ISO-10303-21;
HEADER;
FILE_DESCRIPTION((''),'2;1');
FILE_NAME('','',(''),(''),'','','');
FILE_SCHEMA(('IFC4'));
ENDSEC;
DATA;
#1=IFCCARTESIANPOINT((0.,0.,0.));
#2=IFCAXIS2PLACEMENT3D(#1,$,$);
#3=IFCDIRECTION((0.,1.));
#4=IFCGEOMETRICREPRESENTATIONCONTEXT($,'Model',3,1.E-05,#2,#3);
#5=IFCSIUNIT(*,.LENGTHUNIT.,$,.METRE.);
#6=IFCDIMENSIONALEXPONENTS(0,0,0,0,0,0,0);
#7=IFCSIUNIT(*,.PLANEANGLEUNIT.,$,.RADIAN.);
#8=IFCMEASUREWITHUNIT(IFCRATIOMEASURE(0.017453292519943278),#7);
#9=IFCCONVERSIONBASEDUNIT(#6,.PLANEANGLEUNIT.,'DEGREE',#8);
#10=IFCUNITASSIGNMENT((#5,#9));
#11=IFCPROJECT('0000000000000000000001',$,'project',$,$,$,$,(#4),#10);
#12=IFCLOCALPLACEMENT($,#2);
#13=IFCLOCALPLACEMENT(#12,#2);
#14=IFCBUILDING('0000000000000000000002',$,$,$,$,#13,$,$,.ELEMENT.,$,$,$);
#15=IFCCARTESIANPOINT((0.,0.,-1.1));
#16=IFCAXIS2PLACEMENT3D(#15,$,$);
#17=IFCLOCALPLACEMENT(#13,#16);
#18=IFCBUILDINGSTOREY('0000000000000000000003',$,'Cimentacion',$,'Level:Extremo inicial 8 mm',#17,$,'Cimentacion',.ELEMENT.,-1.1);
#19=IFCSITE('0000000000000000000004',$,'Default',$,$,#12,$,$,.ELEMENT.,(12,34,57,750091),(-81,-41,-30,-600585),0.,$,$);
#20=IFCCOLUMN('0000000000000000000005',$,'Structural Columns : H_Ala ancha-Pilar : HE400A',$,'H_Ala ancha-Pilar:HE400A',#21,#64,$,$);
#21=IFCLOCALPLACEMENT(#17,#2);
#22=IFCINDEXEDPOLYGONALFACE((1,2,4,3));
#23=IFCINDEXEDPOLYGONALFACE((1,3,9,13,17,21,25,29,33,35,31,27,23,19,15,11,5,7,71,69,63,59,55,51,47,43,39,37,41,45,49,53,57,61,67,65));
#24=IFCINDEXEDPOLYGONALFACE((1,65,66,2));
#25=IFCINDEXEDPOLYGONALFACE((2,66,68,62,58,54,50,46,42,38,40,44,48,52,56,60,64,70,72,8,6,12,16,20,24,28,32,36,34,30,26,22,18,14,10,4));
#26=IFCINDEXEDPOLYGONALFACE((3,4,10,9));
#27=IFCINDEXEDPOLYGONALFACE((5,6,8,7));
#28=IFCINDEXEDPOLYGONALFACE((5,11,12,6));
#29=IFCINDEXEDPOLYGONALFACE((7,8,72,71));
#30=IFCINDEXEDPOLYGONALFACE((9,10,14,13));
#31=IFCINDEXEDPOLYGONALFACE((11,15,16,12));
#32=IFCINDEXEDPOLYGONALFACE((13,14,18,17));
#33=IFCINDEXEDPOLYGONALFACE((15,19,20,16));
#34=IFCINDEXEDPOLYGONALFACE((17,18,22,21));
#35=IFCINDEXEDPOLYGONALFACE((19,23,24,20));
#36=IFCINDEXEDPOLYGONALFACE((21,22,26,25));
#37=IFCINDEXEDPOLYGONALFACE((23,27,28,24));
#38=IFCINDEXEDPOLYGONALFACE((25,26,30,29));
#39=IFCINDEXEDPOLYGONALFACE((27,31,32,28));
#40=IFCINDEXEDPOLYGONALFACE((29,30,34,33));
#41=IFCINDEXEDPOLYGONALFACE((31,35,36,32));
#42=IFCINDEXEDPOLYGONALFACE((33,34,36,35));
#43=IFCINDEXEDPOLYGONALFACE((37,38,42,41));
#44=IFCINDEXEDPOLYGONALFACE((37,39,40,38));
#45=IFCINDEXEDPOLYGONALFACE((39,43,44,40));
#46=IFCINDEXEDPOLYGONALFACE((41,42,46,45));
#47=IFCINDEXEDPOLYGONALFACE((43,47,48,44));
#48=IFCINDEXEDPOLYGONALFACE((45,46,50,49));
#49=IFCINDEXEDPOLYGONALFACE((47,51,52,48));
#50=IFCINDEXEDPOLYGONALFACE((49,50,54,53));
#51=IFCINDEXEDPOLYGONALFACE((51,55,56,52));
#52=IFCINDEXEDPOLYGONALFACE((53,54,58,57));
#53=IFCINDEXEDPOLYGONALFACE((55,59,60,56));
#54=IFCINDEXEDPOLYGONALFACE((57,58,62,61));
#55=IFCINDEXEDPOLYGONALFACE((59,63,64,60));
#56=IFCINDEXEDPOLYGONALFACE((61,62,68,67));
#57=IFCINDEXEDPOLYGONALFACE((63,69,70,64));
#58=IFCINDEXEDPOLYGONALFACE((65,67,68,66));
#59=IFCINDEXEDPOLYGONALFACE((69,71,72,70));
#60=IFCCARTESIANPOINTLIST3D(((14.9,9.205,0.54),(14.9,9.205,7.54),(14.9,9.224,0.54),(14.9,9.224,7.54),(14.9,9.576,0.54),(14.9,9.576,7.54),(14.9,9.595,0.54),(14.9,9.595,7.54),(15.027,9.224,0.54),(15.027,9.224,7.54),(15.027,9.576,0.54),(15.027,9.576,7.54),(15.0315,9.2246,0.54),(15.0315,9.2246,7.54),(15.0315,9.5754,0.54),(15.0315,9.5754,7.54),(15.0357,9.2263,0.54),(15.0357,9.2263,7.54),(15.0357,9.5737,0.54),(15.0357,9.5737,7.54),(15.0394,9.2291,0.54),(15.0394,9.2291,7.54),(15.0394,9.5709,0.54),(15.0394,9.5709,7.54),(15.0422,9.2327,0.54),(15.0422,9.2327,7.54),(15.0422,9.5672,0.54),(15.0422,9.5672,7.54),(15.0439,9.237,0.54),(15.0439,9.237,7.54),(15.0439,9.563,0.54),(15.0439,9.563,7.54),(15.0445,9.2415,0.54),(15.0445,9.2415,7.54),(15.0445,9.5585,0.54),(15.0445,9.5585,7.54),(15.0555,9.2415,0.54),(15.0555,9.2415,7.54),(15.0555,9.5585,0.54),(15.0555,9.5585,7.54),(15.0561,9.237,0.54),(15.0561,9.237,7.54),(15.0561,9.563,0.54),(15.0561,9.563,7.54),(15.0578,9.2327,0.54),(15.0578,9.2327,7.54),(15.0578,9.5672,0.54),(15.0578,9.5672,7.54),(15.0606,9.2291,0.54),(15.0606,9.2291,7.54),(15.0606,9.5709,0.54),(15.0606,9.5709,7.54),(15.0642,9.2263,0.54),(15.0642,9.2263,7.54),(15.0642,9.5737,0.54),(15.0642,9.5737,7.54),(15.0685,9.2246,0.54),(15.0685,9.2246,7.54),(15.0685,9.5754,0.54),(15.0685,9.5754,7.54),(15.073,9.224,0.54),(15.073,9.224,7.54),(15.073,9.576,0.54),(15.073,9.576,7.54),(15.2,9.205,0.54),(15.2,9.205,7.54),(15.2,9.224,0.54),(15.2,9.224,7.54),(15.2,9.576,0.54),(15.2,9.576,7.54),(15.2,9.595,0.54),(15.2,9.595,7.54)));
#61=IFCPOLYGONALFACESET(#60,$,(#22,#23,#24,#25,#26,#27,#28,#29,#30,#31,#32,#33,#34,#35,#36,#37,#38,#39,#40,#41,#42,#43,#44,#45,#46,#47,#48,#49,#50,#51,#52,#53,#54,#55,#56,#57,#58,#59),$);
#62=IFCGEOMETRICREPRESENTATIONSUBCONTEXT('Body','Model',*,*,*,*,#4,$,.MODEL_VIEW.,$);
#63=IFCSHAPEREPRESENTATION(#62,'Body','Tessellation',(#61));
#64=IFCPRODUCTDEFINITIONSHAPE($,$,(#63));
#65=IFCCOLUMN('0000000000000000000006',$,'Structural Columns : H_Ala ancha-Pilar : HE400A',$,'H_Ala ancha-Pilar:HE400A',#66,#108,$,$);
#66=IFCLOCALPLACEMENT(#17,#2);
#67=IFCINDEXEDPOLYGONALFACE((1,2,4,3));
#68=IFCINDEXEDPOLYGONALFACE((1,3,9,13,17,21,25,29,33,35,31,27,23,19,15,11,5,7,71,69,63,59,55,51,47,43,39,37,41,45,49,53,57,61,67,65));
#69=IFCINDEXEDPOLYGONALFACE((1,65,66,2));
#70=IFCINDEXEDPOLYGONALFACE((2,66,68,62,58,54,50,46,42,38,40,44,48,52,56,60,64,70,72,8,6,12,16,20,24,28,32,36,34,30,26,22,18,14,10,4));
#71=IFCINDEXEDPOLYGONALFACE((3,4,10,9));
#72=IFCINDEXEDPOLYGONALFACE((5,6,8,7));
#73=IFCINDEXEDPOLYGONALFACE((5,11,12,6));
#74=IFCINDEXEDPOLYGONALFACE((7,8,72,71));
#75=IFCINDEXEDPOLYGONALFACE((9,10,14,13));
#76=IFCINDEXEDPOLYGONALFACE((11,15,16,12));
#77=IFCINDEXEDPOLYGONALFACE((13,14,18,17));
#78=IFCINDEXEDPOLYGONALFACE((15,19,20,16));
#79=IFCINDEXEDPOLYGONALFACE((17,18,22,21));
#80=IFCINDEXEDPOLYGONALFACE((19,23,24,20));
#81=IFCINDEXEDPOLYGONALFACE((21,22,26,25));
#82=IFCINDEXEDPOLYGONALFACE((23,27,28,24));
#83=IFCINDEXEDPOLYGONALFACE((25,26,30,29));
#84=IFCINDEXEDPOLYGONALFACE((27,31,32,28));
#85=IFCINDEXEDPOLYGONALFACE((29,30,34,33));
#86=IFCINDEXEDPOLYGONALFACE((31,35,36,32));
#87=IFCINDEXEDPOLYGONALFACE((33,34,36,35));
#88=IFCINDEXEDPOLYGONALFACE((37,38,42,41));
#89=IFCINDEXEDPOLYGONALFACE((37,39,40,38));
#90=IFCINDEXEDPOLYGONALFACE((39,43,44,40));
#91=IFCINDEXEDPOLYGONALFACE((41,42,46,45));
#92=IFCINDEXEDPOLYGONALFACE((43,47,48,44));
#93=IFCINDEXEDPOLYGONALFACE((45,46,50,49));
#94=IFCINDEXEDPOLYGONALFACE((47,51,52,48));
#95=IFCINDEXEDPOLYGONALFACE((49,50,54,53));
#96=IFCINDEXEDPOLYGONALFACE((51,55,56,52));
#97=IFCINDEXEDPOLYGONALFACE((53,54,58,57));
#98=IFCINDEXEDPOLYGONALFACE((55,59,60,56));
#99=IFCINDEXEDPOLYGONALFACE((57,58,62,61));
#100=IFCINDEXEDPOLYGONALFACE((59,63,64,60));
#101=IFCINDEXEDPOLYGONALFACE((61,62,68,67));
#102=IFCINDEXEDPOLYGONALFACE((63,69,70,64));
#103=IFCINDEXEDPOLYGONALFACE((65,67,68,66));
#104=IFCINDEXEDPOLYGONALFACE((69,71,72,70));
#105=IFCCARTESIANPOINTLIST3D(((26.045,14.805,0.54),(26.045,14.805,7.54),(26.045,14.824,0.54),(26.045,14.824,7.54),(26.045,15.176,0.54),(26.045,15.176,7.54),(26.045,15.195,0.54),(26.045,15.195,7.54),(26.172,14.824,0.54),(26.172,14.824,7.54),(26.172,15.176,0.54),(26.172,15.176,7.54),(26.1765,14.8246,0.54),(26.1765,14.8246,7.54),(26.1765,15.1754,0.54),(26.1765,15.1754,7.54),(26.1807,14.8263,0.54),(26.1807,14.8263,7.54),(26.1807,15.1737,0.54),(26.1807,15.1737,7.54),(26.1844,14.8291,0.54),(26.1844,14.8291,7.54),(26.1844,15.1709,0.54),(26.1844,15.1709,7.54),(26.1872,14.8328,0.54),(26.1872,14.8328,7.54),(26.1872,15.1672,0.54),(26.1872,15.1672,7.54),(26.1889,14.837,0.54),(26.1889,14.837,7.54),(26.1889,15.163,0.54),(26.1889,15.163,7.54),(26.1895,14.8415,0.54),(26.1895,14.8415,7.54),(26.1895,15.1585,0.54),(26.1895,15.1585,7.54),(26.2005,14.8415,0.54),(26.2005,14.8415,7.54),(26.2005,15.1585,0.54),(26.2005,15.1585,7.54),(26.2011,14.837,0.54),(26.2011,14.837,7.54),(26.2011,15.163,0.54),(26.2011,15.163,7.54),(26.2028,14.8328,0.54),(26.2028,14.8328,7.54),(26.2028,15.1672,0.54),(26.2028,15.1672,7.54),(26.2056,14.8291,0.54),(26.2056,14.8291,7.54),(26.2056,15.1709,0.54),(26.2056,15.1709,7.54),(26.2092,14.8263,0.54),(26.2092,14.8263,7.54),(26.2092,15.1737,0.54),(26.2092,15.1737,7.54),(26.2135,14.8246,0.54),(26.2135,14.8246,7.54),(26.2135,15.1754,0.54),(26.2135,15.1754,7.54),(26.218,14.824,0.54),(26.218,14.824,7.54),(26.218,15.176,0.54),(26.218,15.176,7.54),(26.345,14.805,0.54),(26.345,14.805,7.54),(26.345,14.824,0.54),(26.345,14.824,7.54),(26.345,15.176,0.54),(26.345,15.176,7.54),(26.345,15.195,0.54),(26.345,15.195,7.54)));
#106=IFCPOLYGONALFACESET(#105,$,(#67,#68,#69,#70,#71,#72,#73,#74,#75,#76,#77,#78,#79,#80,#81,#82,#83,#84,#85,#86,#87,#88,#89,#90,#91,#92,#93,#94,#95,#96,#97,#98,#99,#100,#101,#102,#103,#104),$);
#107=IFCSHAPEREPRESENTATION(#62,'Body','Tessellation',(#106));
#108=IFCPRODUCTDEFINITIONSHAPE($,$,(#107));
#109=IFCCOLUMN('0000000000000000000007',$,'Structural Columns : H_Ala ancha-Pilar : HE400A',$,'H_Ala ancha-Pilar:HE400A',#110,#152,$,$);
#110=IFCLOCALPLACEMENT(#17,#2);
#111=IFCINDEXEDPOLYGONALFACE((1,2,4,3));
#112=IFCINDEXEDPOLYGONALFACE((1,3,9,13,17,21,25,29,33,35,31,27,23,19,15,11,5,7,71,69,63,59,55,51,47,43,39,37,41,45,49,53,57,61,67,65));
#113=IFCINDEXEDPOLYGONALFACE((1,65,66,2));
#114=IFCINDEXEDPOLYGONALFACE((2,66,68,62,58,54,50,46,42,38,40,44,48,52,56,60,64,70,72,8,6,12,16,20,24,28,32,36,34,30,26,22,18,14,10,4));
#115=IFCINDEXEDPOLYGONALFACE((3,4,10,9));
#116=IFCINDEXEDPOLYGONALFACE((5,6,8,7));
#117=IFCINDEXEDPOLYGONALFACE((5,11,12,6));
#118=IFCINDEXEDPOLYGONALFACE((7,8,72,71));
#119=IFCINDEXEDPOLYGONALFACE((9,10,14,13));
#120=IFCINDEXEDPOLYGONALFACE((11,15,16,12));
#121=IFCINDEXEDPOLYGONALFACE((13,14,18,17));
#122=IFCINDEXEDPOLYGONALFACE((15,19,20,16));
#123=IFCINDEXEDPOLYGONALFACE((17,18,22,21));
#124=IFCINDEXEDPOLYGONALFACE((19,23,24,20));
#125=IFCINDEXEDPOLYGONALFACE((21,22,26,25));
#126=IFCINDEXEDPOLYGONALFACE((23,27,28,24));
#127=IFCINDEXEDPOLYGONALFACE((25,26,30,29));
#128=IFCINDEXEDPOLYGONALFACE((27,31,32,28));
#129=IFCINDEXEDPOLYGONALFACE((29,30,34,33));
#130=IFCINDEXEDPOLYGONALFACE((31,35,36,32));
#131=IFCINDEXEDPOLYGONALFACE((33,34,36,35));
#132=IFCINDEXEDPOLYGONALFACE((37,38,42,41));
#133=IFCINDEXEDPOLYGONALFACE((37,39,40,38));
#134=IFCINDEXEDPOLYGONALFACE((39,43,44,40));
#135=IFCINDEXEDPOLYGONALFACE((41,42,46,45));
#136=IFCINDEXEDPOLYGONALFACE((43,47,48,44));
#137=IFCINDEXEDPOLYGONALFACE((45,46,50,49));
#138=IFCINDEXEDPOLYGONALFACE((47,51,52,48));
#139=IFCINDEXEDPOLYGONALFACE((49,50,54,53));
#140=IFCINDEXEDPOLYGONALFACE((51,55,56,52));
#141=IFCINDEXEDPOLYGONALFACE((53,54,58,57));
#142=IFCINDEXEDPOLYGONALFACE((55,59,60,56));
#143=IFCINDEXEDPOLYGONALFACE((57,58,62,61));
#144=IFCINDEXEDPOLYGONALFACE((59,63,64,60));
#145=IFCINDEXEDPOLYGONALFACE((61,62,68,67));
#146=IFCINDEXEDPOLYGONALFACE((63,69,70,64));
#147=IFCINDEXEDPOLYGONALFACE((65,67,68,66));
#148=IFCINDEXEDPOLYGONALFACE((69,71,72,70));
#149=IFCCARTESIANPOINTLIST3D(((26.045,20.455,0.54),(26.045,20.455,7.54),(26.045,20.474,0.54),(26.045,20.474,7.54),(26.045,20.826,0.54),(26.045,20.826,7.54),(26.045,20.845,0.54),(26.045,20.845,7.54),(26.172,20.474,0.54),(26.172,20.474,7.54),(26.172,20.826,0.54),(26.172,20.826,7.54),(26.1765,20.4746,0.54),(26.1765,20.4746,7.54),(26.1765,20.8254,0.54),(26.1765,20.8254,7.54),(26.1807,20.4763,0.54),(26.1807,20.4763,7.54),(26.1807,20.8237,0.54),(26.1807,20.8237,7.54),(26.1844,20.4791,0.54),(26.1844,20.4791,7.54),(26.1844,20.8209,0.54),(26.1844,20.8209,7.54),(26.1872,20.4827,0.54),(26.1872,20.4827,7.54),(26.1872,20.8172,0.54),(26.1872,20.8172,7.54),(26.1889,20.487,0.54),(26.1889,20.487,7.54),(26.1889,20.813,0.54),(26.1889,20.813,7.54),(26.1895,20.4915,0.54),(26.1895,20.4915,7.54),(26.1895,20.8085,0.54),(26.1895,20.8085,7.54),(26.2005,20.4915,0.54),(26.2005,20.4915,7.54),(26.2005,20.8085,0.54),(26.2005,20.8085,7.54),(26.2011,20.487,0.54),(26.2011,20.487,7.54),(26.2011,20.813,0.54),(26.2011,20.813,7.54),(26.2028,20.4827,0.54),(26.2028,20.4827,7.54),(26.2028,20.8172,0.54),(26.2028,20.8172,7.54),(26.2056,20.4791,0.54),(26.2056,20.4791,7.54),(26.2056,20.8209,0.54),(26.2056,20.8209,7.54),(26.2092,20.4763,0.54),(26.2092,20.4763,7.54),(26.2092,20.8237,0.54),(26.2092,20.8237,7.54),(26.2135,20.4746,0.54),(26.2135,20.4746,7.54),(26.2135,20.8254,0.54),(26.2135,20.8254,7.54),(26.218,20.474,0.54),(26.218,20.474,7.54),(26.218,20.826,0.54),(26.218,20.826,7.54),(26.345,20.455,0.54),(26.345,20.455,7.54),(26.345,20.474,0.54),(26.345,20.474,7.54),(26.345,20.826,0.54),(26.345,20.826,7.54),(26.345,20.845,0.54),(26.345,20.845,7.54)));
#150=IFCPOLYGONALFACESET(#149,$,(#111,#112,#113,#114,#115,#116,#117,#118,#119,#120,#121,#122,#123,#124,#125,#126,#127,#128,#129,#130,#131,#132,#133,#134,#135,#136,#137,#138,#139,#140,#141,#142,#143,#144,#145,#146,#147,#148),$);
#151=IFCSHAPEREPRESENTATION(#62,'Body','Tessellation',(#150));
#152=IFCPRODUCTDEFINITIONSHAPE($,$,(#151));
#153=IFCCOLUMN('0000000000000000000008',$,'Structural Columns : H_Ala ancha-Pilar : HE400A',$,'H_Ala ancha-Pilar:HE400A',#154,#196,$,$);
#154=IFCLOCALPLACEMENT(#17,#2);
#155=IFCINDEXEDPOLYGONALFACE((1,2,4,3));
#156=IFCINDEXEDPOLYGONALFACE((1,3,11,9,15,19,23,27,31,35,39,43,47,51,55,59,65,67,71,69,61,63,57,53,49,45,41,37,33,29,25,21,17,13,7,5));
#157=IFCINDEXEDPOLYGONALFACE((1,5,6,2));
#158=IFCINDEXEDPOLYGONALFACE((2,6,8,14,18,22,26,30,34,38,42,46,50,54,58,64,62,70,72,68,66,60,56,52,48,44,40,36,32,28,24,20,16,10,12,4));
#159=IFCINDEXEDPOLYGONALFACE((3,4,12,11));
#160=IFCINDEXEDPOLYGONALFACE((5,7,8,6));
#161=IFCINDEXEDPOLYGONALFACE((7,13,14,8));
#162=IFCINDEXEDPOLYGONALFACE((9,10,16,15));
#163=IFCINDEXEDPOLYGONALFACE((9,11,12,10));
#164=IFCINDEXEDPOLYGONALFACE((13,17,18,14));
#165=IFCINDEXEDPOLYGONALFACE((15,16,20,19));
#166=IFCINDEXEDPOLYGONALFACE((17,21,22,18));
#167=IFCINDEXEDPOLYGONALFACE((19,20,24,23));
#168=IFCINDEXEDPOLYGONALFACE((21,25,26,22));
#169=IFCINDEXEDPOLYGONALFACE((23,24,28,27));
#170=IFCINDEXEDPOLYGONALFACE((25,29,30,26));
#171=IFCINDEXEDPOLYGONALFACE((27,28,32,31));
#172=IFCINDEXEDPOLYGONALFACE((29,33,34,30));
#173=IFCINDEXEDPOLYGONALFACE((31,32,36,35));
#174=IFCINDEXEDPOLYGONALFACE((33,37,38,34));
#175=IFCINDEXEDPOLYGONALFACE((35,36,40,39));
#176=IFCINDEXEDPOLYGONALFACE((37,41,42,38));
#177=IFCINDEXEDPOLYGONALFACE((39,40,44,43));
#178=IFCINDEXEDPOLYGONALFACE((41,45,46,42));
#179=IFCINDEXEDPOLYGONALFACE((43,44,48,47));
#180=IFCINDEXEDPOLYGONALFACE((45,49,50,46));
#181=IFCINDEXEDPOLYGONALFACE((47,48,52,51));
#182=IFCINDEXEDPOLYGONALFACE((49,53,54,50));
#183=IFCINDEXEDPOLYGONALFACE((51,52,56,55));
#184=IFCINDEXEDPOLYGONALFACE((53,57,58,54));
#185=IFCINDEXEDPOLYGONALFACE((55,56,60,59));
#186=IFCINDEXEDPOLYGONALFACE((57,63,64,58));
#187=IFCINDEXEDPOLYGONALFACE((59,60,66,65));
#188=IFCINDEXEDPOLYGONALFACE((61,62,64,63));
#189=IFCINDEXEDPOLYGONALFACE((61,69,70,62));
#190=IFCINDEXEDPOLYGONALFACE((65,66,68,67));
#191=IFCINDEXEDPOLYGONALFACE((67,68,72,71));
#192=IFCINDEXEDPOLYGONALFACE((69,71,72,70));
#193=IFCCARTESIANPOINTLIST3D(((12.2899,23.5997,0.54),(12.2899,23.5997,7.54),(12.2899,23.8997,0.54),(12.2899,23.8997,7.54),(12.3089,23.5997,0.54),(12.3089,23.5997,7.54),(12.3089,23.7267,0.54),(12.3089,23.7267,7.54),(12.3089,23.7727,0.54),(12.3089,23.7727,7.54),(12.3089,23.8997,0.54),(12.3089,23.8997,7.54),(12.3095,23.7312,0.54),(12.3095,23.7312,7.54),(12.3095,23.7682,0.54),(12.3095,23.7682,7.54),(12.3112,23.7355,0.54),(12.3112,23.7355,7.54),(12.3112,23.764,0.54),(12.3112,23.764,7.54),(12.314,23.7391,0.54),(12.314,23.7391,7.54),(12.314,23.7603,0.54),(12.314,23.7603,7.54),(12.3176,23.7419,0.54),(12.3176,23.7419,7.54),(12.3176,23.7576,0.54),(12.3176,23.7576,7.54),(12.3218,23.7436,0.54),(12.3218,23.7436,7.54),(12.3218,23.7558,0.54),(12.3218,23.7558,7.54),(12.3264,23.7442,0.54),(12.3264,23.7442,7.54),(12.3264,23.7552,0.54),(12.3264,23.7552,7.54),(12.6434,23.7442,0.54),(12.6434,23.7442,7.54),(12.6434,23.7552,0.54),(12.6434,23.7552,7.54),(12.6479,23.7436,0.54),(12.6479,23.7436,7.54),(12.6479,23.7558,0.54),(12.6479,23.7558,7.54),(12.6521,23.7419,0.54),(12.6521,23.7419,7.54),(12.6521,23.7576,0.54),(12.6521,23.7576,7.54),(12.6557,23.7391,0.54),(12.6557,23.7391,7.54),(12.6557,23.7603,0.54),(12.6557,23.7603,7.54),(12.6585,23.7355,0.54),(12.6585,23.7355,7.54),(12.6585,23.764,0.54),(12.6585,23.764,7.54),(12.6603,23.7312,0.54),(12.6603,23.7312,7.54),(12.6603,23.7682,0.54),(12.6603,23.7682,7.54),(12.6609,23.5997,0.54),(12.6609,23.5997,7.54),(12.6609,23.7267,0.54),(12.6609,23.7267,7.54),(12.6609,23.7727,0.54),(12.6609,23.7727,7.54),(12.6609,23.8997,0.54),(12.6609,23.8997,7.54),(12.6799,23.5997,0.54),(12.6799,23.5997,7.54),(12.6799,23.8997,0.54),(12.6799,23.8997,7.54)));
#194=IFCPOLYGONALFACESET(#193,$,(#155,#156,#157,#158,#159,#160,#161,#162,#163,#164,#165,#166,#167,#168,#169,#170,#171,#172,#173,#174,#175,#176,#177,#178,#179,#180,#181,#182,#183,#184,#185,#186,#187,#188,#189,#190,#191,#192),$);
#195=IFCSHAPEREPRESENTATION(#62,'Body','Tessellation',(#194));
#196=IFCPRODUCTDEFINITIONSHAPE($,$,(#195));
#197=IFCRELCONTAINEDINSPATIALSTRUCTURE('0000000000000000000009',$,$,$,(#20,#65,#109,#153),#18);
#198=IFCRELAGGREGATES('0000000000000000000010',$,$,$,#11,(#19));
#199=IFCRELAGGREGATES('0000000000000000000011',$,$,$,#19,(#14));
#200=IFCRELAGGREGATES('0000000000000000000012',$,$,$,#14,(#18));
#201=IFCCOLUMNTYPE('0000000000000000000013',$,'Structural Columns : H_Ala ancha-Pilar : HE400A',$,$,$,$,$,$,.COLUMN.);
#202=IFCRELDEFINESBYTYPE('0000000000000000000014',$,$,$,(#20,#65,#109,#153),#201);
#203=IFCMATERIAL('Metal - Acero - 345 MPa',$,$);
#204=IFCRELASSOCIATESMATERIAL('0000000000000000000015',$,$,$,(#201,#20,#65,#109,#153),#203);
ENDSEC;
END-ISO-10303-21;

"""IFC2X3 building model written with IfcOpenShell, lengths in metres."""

from ifc_helpers import new_model, entity, si_unit, converted_unit, direction, frame, frame_2d, origin, place, context, subcontext, project, spatial, polyline, circle_curve, parameter, trimmed, segment, composite_curve, outline, extrude, source, transform, mapped, material, type_object, type_shapes, element, save


model = new_model("IFC2X3")

# Units and contexts
model_context = context("Model", 3, precision=1e-05, world=origin(), true_north=direction((0.0, 1.0)))
body_context = subcontext(model_context, "Body", "Model", "MODEL_VIEW")
ifc_project = project(units=[si_unit("LENGTHUNIT", "METRE"), converted_unit("PLANEANGLEUNIT", "DEGREE", entity("IfcRatioMeasure", 0.017453292519943278), si_unit("PLANEANGLEUNIT", "RADIAN"), dimensions=[0, 0, 0, 0, 0, 0, 0])], contexts=[model_context])

# Site, building, storey
site_placement = place(None, origin())
site = spatial("IfcSite", under=ifc_project, at=site_placement, Name="Default", CompositionType="ELEMENT", RefLatitude=(12, 34, 57, 750091), RefLongitude=(-81, -41, -30, -600585), RefElevation=0.0)
building_placement = place(site_placement, origin())
building = spatial("IfcBuilding", under=site, at=building_placement, CompositionType="ELEMENT")
storey_placement = place(building_placement, frame((0.0, 0.0, -1.1)))
storey = spatial("IfcBuildingStorey", under=building, at=storey_placement, Name="Cimentacion", ObjectType="Level:Extremo inicial 8 mm", LongName="Cimentacion", CompositionType="ELEMENT", Elevation=-1.1)

# Columns
ifc_material = material(Name="Metal - Acero - 345 MPa")
column_type_1 = type_object("IfcColumnType", Name="Structural Columns : H_Ala ancha-Pilar : HE400A", PredefinedType="COLUMN", material=ifc_material)
shared_shape_1 = source(origin(), body_context, "Body", "SweptSolid", [
    extrude(outline(composite_curve([segment(polyline([(0.176, -0.15), (0.195, -0.15)]), True, "CONTINUOUS"), segment(polyline([(0.195, -0.15), (0.195, 0.15)]), True, "CONTINUOUS"), segment(polyline([(0.195, 0.15), (0.176, 0.15)]), True, "CONTINUOUS"), segment(polyline([(0.176, 0.15), (0.176, 0.023)]), True, "CONTINUOUS"), segment(trimmed(circle_curve(frame_2d((0.1585, 0.023), x_axis=(1.0, 0.0)), 0.0175), [parameter(270.0)], [parameter(0.0)], True, "PARAMETER"), False, "CONTINUOUS"), segment(polyline([(0.1585, 0.0055), (-0.1585, 0.0055)]), True, "CONTINUOUS"), segment(trimmed(circle_curve(frame_2d((-0.1585, 0.023), x_axis=(0.0, -1.0)), 0.0175), [parameter(270.0)], [parameter(0.0)], True, "PARAMETER"), False, "CONTINUOUS"), segment(polyline([(-0.176, 0.023), (-0.176, 0.15)]), True, "CONTINUOUS"), segment(polyline([(-0.176, 0.15), (-0.195, 0.15)]), True, "CONTINUOUS"), segment(polyline([(-0.195, 0.15), (-0.195, -0.15)]), True, "CONTINUOUS"), segment(polyline([(-0.195, -0.15), (-0.176, -0.15)]), True, "CONTINUOUS"), segment(polyline([(-0.176, -0.15), (-0.176, -0.023)]), True, "CONTINUOUS"), segment(trimmed(circle_curve(frame_2d((-0.1585, -0.023), x_axis=(-1.0, 0.0)), 0.0175), [parameter(270.0)], [parameter(0.0)], True, "PARAMETER"), False, "CONTINUOUS"), segment(polyline([(-0.1585, -0.0055), (0.1585, -0.0055)]), True, "CONTINUOUS"), segment(trimmed(circle_curve(frame_2d((0.1585, -0.023), x_axis=(0.0, 1.0)), 0.0175), [parameter(270.0)], [parameter(0.0)], True, "PARAMETER"), False, "CONTINUOUS"), segment(polyline([(0.176, -0.023), (0.176, -0.15)]), True, "CONTINUOUS")], self_intersect=False)), frame((0.0, 0.0, -0.56), z_axis=(0.0, 0.0, 1.0), x_axis=(0.0, -1.0, 0.0)), (0.0, 0.0, 1.0), 7.0),
])
type_shapes(column_type_1, [shared_shape_1])
for number, where, z_axis, x_axis, name in (
    (1, (15.05, 9.4, 1.1), (0.0, 0.0, 1.0), (-1.0, 0.0, 0.0), "Structural Columns : H_Ala ancha-Pilar : HE400A"),
    (2, (26.195, 15.0, 1.1), (0.0, 0.0, 1.0), (-1.0, 0.0, 0.0), "Structural Columns : H_Ala ancha-Pilar : HE400A"),
    (3, (26.195, 20.65, 1.1), (0.0, 0.0, 1.0), (-1.0, 0.0, 0.0), "Structural Columns : H_Ala ancha-Pilar : HE400A"),
    (4, (12.4849, 23.7497, 1.1), (0.0, 0.0, 1.0), (0.0, 1.0, 0.0), "Structural Columns : H_Ala ancha-Pilar : HE400A"),
):
    element("IfcColumn", number, at=place(storey_placement, frame(where, z_axis=z_axis, x_axis=x_axis)), inside=storey, type_object=column_type_1, material=ifc_material, Name=name, ObjectType="H_Ala ancha-Pilar:HE400A", context=body_context, shape_type="MappedRepresentation", body=[
        mapped(shared_shape_1, transform((0.0, 0.0, 0.0), scale=1.0)),
    ])

save(model, "model.ifc")
